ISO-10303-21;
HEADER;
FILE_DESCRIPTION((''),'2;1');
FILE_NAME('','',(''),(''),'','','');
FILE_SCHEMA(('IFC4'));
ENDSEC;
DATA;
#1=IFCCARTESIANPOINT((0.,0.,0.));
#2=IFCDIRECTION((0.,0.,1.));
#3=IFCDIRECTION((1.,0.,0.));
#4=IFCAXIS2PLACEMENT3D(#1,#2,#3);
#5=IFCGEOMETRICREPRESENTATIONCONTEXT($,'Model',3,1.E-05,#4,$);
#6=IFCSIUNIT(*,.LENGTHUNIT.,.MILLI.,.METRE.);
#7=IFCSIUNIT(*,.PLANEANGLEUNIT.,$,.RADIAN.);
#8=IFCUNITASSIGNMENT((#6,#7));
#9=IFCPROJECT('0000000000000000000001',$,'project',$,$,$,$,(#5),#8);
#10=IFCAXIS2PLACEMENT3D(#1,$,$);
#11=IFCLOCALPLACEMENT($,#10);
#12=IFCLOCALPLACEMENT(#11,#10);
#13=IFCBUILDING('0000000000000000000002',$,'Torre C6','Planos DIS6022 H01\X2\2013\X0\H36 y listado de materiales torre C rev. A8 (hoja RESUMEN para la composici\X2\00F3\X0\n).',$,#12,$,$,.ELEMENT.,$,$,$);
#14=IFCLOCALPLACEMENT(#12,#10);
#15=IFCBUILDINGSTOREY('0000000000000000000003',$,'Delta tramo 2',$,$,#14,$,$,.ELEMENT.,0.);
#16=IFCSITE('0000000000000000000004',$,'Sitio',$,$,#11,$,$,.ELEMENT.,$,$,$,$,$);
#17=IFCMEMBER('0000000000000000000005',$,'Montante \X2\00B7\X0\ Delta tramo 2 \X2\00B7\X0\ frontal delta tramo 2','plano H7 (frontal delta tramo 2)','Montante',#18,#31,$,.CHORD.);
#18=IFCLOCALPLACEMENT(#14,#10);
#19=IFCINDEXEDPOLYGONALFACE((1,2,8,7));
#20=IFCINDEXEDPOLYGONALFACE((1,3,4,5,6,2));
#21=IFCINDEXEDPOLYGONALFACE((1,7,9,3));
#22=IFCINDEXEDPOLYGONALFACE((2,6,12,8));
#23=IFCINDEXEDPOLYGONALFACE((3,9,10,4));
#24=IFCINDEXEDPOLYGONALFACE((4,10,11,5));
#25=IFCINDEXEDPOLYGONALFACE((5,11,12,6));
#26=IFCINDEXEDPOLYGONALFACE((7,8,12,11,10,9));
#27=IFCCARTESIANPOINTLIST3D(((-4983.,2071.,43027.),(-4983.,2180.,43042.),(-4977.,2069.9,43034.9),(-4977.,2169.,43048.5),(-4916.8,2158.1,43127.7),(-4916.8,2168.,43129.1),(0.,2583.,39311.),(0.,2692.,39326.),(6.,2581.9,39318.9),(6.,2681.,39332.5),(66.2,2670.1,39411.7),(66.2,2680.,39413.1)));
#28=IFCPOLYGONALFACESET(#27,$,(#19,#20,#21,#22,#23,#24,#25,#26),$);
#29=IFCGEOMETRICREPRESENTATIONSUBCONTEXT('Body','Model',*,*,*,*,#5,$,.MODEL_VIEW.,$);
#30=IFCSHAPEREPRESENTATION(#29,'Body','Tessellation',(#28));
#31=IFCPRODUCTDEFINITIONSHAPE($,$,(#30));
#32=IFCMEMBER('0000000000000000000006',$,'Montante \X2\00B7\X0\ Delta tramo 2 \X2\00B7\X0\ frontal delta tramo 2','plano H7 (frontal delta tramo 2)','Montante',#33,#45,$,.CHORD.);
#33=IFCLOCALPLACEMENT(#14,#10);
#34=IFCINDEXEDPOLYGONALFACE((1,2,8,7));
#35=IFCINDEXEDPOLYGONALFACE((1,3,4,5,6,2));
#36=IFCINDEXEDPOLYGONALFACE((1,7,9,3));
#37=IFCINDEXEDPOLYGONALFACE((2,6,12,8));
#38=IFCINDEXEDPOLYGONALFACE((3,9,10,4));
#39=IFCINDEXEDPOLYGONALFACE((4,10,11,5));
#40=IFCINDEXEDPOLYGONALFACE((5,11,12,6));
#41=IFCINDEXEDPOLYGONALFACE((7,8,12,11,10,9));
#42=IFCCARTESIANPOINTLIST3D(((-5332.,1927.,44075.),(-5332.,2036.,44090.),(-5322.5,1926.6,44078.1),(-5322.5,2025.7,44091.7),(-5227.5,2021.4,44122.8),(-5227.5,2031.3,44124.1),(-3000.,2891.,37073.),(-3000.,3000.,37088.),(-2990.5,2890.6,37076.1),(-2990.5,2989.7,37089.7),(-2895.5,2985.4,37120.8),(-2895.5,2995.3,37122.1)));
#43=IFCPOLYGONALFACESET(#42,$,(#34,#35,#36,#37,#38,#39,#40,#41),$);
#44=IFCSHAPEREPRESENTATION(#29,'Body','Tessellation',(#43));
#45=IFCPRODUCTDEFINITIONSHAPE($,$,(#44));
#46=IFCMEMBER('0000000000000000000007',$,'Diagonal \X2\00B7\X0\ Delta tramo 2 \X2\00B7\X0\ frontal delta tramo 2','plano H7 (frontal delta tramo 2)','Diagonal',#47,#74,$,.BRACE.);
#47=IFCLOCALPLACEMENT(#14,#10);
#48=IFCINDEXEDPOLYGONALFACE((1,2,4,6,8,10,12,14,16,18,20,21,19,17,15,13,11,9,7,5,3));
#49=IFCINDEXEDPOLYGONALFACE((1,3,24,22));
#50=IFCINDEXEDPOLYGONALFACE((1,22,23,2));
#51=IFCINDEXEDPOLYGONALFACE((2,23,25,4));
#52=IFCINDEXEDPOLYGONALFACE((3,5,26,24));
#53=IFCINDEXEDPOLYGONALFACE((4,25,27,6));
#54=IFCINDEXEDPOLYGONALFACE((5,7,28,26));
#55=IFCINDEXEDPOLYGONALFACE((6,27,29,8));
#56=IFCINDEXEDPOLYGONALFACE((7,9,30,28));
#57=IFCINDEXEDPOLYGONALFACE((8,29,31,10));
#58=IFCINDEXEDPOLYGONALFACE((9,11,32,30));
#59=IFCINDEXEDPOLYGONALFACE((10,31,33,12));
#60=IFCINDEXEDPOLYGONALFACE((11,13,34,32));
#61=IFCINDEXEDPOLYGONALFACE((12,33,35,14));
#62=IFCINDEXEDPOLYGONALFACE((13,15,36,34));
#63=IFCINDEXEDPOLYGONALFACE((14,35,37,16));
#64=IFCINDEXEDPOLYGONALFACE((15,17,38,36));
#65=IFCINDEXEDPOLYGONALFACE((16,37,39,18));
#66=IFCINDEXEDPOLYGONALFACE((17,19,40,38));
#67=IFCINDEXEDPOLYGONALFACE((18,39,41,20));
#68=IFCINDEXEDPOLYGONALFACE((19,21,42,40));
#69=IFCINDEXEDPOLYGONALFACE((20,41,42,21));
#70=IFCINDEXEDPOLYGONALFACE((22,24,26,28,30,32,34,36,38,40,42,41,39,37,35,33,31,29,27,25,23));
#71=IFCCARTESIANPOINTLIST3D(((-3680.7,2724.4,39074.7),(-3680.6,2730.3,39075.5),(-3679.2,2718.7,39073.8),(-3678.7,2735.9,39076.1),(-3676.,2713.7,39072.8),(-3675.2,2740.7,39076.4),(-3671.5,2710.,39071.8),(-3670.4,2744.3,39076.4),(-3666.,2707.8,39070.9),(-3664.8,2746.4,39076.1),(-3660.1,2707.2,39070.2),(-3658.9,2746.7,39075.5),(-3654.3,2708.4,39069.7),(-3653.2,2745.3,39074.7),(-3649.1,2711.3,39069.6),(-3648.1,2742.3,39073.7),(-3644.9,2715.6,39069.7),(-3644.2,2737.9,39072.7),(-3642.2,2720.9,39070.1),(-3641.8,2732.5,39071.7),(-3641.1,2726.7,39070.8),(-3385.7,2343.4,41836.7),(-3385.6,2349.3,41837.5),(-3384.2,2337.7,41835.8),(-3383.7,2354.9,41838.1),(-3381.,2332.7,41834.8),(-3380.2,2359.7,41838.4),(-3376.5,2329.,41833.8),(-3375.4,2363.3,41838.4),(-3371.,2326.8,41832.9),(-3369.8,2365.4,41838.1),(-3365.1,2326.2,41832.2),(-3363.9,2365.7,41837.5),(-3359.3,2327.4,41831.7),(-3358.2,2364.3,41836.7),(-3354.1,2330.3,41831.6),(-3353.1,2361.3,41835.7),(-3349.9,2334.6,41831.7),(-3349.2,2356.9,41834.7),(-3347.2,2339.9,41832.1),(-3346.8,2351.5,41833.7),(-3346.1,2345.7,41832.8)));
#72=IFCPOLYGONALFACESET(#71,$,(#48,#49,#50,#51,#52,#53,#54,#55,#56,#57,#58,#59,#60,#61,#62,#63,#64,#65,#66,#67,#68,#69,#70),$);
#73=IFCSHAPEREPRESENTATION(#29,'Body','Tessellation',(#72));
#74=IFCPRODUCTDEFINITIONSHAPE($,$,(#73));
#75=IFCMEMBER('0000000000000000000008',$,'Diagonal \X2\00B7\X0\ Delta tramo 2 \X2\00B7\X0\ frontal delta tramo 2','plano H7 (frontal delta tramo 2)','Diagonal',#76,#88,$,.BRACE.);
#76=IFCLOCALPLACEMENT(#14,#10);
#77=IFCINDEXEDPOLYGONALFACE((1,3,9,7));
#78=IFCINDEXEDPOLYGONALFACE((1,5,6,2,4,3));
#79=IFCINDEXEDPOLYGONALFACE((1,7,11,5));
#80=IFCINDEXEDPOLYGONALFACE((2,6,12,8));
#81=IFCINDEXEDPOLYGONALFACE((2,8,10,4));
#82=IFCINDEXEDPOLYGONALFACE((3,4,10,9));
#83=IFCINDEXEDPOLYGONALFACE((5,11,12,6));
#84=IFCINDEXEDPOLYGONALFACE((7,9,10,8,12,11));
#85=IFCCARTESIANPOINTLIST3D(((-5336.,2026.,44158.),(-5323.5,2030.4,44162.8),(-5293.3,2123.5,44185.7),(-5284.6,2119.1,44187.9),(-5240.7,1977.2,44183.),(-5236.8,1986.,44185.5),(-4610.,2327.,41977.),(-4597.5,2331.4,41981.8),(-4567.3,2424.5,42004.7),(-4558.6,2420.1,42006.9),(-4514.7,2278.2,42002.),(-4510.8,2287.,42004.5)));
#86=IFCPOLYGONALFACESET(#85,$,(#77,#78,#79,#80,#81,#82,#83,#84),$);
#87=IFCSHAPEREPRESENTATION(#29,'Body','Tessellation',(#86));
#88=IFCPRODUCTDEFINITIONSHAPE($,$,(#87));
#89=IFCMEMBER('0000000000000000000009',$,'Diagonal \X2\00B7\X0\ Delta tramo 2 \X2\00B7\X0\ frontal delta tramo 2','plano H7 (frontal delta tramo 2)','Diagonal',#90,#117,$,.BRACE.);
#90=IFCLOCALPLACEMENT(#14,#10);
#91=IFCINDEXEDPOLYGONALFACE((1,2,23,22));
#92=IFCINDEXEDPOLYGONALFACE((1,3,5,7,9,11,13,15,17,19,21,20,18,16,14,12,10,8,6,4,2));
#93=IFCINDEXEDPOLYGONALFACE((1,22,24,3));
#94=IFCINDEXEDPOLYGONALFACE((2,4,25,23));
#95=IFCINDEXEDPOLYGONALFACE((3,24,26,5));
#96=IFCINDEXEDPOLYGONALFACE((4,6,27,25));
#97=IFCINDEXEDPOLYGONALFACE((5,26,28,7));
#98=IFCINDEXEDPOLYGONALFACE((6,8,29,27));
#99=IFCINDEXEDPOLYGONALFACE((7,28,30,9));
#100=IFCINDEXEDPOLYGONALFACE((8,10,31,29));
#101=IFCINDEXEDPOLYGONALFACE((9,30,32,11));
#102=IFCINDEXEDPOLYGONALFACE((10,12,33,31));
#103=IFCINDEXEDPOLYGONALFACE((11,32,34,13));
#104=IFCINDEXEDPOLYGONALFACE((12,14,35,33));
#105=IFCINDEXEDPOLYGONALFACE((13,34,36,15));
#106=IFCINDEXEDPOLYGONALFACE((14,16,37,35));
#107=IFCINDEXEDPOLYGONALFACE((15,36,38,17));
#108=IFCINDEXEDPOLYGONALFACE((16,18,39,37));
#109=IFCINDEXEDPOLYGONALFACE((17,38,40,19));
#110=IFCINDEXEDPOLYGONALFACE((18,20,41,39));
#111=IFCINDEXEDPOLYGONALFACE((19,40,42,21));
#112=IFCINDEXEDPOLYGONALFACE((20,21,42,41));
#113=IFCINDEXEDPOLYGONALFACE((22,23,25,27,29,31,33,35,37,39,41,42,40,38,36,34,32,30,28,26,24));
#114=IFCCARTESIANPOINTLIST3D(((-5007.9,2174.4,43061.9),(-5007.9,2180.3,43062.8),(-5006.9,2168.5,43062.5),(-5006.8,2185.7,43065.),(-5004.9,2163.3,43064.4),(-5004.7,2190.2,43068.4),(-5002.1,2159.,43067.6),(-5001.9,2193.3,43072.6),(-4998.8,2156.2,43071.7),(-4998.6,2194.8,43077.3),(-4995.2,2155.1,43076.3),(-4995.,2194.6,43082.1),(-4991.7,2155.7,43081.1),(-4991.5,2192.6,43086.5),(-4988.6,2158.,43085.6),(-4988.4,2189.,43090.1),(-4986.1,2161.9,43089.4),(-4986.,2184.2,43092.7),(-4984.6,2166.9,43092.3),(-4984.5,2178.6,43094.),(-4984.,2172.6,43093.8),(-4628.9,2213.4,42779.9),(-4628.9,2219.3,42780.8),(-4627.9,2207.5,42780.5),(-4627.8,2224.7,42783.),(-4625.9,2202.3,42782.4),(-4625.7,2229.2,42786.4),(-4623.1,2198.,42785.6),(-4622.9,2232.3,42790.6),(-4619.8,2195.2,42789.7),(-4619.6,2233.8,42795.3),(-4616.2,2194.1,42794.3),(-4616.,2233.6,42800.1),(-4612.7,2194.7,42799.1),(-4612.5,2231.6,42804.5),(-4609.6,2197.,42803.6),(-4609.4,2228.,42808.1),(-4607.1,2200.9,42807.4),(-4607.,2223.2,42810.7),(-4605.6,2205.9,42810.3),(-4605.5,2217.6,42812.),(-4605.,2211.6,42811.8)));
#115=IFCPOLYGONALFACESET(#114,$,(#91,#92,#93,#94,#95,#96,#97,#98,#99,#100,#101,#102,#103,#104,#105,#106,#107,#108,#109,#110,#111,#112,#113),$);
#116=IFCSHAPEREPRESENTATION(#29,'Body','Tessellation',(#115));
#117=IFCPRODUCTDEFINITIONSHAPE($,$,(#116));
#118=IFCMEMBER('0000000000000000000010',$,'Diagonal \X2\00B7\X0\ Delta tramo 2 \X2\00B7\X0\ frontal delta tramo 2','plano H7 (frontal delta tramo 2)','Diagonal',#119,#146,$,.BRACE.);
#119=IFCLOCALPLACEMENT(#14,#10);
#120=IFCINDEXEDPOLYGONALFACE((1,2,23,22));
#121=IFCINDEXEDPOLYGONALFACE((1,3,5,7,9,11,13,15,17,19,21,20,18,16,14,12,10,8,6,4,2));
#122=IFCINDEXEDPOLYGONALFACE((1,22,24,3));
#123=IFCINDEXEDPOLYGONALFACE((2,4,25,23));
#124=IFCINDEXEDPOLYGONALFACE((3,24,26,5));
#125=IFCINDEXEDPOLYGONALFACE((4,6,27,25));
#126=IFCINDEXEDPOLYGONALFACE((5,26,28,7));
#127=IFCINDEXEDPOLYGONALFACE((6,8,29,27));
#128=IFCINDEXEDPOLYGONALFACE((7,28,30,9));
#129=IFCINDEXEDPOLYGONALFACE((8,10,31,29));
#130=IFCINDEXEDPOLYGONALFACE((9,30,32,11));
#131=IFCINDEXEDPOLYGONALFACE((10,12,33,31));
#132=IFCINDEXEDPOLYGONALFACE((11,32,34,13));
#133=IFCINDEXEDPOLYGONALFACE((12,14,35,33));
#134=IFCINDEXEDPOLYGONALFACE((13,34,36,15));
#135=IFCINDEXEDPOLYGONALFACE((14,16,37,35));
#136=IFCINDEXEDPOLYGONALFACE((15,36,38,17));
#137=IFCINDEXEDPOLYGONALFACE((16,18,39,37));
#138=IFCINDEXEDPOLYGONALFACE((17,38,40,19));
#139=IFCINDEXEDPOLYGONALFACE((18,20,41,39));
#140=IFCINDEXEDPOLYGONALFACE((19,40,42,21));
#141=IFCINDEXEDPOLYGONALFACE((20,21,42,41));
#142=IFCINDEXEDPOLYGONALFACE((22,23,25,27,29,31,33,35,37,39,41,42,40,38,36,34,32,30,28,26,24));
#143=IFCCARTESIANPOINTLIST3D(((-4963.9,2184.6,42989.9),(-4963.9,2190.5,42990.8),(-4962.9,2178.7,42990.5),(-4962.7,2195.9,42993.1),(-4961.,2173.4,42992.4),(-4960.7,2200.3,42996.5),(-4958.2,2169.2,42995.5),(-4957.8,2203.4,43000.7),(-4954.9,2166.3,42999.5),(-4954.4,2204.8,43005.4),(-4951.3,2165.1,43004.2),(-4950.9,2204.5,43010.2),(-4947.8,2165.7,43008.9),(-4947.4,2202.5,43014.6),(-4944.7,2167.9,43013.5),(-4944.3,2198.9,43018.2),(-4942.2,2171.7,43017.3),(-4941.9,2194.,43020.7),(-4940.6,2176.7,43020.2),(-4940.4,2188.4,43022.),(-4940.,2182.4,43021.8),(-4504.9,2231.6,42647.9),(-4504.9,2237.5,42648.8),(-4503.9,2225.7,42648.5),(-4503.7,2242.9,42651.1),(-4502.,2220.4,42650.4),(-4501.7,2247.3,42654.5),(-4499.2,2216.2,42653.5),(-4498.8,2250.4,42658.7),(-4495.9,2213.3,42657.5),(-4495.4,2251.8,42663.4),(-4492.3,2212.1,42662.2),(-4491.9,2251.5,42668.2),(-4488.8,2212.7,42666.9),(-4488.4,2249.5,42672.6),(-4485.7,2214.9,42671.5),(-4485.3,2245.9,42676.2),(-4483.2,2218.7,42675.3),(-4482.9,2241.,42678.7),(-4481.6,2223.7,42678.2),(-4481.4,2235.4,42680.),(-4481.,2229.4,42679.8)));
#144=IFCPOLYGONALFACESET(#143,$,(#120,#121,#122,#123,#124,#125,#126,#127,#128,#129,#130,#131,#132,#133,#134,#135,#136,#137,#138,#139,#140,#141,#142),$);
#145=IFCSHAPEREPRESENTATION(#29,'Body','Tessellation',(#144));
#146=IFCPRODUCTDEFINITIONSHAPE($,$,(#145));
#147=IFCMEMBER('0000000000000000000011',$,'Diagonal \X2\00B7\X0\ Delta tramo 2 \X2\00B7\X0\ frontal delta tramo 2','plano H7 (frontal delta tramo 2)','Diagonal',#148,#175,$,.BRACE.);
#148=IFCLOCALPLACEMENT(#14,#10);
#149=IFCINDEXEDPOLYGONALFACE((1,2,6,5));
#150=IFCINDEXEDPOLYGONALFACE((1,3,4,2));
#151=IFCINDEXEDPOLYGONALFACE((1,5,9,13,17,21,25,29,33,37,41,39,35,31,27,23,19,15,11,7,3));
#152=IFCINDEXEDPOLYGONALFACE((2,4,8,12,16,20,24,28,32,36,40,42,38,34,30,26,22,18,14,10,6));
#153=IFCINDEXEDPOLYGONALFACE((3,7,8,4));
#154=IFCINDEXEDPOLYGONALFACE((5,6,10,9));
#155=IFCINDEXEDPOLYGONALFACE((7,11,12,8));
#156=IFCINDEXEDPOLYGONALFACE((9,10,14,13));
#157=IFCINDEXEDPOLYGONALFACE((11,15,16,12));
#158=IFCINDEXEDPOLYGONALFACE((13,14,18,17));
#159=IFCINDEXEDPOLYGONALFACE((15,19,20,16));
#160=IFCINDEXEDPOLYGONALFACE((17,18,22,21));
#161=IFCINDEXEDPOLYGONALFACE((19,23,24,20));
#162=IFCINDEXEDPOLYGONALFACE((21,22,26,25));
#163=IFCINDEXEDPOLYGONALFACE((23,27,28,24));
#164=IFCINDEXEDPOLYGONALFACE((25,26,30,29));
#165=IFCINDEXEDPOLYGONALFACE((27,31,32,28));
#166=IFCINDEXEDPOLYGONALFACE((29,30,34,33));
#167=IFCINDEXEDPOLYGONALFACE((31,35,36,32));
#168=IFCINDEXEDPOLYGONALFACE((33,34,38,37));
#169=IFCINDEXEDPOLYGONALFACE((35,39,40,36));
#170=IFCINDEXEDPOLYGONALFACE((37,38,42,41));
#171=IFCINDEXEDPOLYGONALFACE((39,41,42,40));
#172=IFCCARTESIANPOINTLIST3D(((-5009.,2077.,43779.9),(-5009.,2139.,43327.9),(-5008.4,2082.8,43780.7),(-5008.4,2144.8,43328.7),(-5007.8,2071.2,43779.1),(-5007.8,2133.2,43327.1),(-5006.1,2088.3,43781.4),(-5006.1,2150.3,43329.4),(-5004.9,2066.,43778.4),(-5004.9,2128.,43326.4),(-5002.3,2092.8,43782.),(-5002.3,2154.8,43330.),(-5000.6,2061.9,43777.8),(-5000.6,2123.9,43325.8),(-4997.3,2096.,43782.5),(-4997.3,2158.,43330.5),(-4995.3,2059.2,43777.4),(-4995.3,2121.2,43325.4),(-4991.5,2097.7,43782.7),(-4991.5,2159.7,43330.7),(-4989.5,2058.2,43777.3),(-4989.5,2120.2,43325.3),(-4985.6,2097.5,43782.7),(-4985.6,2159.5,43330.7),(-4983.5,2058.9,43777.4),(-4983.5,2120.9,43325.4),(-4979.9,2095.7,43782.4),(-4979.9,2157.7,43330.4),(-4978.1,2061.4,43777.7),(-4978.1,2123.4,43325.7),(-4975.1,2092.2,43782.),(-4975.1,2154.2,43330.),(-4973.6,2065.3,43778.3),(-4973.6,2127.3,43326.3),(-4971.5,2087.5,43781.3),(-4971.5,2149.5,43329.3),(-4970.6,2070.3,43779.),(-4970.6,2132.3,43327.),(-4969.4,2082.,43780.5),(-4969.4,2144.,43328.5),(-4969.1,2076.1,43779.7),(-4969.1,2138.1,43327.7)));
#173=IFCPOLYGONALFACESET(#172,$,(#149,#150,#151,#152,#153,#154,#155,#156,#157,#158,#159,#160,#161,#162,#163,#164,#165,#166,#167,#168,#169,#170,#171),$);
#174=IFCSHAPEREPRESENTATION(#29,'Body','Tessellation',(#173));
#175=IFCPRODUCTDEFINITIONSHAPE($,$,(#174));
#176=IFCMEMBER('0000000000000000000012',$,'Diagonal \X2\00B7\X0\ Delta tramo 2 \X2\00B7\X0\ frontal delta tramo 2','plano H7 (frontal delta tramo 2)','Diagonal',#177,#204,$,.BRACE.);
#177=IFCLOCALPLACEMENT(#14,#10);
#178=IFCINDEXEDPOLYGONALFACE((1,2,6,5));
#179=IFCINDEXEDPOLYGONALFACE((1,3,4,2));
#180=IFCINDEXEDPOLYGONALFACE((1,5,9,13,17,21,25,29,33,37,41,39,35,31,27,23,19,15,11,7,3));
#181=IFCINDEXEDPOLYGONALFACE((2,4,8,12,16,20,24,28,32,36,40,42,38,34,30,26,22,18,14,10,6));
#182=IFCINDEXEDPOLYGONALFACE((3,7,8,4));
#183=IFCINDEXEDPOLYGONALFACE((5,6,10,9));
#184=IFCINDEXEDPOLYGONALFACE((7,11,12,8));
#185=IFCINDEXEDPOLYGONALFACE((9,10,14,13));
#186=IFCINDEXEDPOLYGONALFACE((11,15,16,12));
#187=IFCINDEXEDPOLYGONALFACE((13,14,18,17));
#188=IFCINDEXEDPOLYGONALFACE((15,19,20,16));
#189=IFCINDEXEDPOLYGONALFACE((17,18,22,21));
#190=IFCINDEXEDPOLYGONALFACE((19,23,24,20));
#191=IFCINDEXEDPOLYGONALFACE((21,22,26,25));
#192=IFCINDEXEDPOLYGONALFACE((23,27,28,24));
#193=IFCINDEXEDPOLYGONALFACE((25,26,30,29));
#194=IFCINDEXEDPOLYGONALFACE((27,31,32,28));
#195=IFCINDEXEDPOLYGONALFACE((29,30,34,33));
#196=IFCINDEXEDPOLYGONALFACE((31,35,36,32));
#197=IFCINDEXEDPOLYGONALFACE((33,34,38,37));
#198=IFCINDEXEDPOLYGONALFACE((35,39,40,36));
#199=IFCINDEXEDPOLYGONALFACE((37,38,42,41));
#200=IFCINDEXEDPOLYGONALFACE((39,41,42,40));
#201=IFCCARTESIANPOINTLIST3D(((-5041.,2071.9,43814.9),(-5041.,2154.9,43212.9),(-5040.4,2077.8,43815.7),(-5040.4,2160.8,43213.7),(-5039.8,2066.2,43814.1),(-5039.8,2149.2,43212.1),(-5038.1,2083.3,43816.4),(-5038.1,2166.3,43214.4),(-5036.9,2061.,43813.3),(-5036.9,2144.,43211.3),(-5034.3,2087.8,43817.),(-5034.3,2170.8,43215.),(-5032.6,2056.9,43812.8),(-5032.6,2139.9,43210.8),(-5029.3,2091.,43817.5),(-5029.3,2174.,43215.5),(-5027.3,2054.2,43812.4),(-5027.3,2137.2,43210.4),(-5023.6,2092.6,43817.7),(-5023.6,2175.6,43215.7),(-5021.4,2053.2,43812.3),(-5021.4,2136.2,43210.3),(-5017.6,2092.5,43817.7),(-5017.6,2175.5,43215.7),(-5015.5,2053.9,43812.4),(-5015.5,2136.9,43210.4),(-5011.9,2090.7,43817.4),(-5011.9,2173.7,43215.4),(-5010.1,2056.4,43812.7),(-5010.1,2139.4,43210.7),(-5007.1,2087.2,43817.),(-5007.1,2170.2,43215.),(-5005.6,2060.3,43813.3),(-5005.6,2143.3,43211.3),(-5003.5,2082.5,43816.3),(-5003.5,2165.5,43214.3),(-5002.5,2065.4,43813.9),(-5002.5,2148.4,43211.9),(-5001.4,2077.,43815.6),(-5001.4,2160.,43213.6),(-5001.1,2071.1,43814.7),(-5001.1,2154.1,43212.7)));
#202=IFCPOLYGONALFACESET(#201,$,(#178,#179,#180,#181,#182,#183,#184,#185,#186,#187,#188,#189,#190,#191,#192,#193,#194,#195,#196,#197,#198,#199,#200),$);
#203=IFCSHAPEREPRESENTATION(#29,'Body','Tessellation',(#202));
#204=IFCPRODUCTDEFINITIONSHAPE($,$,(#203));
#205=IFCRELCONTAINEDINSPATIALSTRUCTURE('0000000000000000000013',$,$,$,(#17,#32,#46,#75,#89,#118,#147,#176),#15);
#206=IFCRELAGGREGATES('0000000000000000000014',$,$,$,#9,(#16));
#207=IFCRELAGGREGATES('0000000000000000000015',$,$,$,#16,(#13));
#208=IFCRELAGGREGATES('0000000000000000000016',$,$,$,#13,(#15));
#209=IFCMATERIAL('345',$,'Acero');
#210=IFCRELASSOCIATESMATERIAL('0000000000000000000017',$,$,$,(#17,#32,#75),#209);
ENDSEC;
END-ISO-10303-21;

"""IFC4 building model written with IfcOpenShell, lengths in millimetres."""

from ifc_helpers import new_model, si_unit, frame, frame_2d, origin, origin_with_axes, place, context, subcontext, project, spatial, circle, l_section, extrude, material, element, save


model = new_model("IFC4")

# Units and contexts
model_context = context("Model", 3, precision=1e-05, world=origin_with_axes())
body_context = subcontext(model_context, "Body", "Model", "MODEL_VIEW")
ifc_project = project(units=[si_unit("LENGTHUNIT", "METRE", prefix="MILLI"), si_unit("PLANEANGLEUNIT", "RADIAN")], contexts=[model_context])

# Site, building, storey
site_placement = place(None, origin())
site = spatial("IfcSite", under=ifc_project, at=site_placement, Name="Sitio", CompositionType="ELEMENT")
building_placement = place(site_placement, origin())
building = spatial("IfcBuilding", under=site, at=building_placement, Name="Torre C6", Description="Planos DIS6022 H01–H36 y listado de materiales torre C rev. A8 (hoja RESUMEN para la composición).", CompositionType="ELEMENT")
storey_placement = place(building_placement, origin())
storey = spatial("IfcBuildingStorey", under=building, at=storey_placement, Name="Delta tramo 2", CompositionType="ELEMENT", Elevation=0.0)

# Members
ifc_material_1 = material(Name="345", Category="Acero")
member_1_placement = place(storey_placement, frame((-4983.0, 2180.0, 43042.0), z_axis=(0.798932, 0.08209, -0.595792), x_axis=(0.601421, -0.109049, 0.791455)))
element("IfcMember", 1, at=member_1_placement, inside=storey, material=ifc_material_1, Name="Montante · Delta tramo 2 · frontal delta tramo 2", Description="plano H7 (frontal delta tramo 2)", ObjectType="Montante", PredefinedType="CHORD", context=body_context, shape_type="SweptSolid", body=[
    extrude(l_section(Depth=110.0, Width=110.0, Thickness=10.0, at=frame_2d((55.0, 55.0))), None, (0.0, 0.0, 1.0), 6237.1),
])
member_2_placement = place(storey_placement, frame((-5332.0, 2036.0, 44090.0), z_axis=(0.313322, 0.129521, -0.940773), x_axis=(0.949647, -0.042734, 0.310394)))
element("IfcMember", 2, at=member_2_placement, inside=storey, material=ifc_material_1, Name="Montante · Delta tramo 2 · frontal delta tramo 2", Description="plano H7 (frontal delta tramo 2)", ObjectType="Montante", PredefinedType="CHORD", context=body_context, shape_type="SweptSolid", body=[
    extrude(l_section(Depth=110.0, Width=110.0, Thickness=10.0, at=frame_2d((55.0, 55.0))), None, (0.0, 0.0, 1.0), 7442.8),
])
member_3_placement = place(storey_placement, frame((-3366.0, 2346.0, 41835.0), z_axis=(-0.105217, 0.135891, -0.985121), x_axis=(0.804453, -0.570742, -0.164651)))
element("IfcMember", 3, at=member_3_placement, inside=storey, Name="Diagonal · Delta tramo 2 · frontal delta tramo 2", Description="plano H7 (frontal delta tramo 2)", ObjectType="Diagonal", PredefinedType="BRACE", context=body_context, shape_type="SweptSolid", body=[
    extrude(circle(Radius=20.0), None, (0.0, 0.0, 1.0), 2803.7),
])
member_4_placement = place(storey_placement, frame((-4610.0, 2327.0, 41977.0), z_axis=(-0.313163, -0.129837, 0.940782), x_axis=(0.866801, -0.443846, 0.227281)))
element("IfcMember", 4, at=member_4_placement, inside=storey, material=ifc_material_1, Name="Diagonal · Delta tramo 2 · frontal delta tramo 2", Description="plano H7 (frontal delta tramo 2)", ObjectType="Diagonal", PredefinedType="BRACE", context=body_context, shape_type="SweptSolid", body=[
    extrude(l_section(Depth=110.0, Width=110.0, Thickness=10.0, at=frame_2d((55.0, 55.0))), None, (0.0, 0.0, 1.0), 2318.3),
])
member_5_placement = place(storey_placement, frame((-4996.0, 2175.0, 43078.0), z_axis=(0.79956, 0.082277, -0.594923), x_axis=(0.493139, -0.655346, 0.572132)))
element("IfcMember", 5, at=member_5_placement, inside=storey, Name="Diagonal · Delta tramo 2 · frontal delta tramo 2", Description="plano H7 (frontal delta tramo 2)", ObjectType="Diagonal", PredefinedType="BRACE", context=body_context, shape_type="SweptSolid", body=[
    extrude(circle(Radius=20.0), None, (0.0, 0.0, 1.0), 474.0),
])
member_6_placement = place(storey_placement, frame((-4952.0, 2185.0, 43006.0), z_axis=(0.799193, 0.081835, -0.595477), x_axis=(0.48996, -0.662562, 0.566524)))
element("IfcMember", 6, at=member_6_placement, inside=storey, Name="Diagonal · Delta tramo 2 · frontal delta tramo 2", Description="plano H7 (frontal delta tramo 2)", ObjectType="Diagonal", PredefinedType="BRACE", context=body_context, shape_type="SweptSolid", body=[
    extrude(circle(Radius=20.0), None, (0.0, 0.0, 1.0), 574.3),
])
member_7_placement = place(storey_placement, frame((-4989.0, 2140.0, 43328.0), z_axis=(0.0, -0.135896, 0.990723), x_axis=(0.922374, -0.382714, -0.052496)))
element("IfcMember", 7, at=member_7_placement, inside=storey, Name="Diagonal · Delta tramo 2 · frontal delta tramo 2", Description="plano H7 (frontal delta tramo 2)", ObjectType="Diagonal", PredefinedType="BRACE", context=body_context, shape_type="SweptSolid", body=[
    extrude(circle(Radius=20.0), None, (0.0, 0.0, 1.0), 456.2),
])
member_8_placement = place(storey_placement, frame((-5021.0, 2156.0, 43213.0), z_axis=(0.0, -0.136582, 0.990629), x_axis=(0.922907, -0.381415, -0.052587)))
element("IfcMember", 8, at=member_8_placement, inside=storey, Name="Diagonal · Delta tramo 2 · frontal delta tramo 2", Description="plano H7 (frontal delta tramo 2)", ObjectType="Diagonal", PredefinedType="BRACE", context=body_context, shape_type="SweptSolid", body=[
    extrude(circle(Radius=20.0), None, (0.0, 0.0, 1.0), 607.7),
])

save(model, "model.ifc")
